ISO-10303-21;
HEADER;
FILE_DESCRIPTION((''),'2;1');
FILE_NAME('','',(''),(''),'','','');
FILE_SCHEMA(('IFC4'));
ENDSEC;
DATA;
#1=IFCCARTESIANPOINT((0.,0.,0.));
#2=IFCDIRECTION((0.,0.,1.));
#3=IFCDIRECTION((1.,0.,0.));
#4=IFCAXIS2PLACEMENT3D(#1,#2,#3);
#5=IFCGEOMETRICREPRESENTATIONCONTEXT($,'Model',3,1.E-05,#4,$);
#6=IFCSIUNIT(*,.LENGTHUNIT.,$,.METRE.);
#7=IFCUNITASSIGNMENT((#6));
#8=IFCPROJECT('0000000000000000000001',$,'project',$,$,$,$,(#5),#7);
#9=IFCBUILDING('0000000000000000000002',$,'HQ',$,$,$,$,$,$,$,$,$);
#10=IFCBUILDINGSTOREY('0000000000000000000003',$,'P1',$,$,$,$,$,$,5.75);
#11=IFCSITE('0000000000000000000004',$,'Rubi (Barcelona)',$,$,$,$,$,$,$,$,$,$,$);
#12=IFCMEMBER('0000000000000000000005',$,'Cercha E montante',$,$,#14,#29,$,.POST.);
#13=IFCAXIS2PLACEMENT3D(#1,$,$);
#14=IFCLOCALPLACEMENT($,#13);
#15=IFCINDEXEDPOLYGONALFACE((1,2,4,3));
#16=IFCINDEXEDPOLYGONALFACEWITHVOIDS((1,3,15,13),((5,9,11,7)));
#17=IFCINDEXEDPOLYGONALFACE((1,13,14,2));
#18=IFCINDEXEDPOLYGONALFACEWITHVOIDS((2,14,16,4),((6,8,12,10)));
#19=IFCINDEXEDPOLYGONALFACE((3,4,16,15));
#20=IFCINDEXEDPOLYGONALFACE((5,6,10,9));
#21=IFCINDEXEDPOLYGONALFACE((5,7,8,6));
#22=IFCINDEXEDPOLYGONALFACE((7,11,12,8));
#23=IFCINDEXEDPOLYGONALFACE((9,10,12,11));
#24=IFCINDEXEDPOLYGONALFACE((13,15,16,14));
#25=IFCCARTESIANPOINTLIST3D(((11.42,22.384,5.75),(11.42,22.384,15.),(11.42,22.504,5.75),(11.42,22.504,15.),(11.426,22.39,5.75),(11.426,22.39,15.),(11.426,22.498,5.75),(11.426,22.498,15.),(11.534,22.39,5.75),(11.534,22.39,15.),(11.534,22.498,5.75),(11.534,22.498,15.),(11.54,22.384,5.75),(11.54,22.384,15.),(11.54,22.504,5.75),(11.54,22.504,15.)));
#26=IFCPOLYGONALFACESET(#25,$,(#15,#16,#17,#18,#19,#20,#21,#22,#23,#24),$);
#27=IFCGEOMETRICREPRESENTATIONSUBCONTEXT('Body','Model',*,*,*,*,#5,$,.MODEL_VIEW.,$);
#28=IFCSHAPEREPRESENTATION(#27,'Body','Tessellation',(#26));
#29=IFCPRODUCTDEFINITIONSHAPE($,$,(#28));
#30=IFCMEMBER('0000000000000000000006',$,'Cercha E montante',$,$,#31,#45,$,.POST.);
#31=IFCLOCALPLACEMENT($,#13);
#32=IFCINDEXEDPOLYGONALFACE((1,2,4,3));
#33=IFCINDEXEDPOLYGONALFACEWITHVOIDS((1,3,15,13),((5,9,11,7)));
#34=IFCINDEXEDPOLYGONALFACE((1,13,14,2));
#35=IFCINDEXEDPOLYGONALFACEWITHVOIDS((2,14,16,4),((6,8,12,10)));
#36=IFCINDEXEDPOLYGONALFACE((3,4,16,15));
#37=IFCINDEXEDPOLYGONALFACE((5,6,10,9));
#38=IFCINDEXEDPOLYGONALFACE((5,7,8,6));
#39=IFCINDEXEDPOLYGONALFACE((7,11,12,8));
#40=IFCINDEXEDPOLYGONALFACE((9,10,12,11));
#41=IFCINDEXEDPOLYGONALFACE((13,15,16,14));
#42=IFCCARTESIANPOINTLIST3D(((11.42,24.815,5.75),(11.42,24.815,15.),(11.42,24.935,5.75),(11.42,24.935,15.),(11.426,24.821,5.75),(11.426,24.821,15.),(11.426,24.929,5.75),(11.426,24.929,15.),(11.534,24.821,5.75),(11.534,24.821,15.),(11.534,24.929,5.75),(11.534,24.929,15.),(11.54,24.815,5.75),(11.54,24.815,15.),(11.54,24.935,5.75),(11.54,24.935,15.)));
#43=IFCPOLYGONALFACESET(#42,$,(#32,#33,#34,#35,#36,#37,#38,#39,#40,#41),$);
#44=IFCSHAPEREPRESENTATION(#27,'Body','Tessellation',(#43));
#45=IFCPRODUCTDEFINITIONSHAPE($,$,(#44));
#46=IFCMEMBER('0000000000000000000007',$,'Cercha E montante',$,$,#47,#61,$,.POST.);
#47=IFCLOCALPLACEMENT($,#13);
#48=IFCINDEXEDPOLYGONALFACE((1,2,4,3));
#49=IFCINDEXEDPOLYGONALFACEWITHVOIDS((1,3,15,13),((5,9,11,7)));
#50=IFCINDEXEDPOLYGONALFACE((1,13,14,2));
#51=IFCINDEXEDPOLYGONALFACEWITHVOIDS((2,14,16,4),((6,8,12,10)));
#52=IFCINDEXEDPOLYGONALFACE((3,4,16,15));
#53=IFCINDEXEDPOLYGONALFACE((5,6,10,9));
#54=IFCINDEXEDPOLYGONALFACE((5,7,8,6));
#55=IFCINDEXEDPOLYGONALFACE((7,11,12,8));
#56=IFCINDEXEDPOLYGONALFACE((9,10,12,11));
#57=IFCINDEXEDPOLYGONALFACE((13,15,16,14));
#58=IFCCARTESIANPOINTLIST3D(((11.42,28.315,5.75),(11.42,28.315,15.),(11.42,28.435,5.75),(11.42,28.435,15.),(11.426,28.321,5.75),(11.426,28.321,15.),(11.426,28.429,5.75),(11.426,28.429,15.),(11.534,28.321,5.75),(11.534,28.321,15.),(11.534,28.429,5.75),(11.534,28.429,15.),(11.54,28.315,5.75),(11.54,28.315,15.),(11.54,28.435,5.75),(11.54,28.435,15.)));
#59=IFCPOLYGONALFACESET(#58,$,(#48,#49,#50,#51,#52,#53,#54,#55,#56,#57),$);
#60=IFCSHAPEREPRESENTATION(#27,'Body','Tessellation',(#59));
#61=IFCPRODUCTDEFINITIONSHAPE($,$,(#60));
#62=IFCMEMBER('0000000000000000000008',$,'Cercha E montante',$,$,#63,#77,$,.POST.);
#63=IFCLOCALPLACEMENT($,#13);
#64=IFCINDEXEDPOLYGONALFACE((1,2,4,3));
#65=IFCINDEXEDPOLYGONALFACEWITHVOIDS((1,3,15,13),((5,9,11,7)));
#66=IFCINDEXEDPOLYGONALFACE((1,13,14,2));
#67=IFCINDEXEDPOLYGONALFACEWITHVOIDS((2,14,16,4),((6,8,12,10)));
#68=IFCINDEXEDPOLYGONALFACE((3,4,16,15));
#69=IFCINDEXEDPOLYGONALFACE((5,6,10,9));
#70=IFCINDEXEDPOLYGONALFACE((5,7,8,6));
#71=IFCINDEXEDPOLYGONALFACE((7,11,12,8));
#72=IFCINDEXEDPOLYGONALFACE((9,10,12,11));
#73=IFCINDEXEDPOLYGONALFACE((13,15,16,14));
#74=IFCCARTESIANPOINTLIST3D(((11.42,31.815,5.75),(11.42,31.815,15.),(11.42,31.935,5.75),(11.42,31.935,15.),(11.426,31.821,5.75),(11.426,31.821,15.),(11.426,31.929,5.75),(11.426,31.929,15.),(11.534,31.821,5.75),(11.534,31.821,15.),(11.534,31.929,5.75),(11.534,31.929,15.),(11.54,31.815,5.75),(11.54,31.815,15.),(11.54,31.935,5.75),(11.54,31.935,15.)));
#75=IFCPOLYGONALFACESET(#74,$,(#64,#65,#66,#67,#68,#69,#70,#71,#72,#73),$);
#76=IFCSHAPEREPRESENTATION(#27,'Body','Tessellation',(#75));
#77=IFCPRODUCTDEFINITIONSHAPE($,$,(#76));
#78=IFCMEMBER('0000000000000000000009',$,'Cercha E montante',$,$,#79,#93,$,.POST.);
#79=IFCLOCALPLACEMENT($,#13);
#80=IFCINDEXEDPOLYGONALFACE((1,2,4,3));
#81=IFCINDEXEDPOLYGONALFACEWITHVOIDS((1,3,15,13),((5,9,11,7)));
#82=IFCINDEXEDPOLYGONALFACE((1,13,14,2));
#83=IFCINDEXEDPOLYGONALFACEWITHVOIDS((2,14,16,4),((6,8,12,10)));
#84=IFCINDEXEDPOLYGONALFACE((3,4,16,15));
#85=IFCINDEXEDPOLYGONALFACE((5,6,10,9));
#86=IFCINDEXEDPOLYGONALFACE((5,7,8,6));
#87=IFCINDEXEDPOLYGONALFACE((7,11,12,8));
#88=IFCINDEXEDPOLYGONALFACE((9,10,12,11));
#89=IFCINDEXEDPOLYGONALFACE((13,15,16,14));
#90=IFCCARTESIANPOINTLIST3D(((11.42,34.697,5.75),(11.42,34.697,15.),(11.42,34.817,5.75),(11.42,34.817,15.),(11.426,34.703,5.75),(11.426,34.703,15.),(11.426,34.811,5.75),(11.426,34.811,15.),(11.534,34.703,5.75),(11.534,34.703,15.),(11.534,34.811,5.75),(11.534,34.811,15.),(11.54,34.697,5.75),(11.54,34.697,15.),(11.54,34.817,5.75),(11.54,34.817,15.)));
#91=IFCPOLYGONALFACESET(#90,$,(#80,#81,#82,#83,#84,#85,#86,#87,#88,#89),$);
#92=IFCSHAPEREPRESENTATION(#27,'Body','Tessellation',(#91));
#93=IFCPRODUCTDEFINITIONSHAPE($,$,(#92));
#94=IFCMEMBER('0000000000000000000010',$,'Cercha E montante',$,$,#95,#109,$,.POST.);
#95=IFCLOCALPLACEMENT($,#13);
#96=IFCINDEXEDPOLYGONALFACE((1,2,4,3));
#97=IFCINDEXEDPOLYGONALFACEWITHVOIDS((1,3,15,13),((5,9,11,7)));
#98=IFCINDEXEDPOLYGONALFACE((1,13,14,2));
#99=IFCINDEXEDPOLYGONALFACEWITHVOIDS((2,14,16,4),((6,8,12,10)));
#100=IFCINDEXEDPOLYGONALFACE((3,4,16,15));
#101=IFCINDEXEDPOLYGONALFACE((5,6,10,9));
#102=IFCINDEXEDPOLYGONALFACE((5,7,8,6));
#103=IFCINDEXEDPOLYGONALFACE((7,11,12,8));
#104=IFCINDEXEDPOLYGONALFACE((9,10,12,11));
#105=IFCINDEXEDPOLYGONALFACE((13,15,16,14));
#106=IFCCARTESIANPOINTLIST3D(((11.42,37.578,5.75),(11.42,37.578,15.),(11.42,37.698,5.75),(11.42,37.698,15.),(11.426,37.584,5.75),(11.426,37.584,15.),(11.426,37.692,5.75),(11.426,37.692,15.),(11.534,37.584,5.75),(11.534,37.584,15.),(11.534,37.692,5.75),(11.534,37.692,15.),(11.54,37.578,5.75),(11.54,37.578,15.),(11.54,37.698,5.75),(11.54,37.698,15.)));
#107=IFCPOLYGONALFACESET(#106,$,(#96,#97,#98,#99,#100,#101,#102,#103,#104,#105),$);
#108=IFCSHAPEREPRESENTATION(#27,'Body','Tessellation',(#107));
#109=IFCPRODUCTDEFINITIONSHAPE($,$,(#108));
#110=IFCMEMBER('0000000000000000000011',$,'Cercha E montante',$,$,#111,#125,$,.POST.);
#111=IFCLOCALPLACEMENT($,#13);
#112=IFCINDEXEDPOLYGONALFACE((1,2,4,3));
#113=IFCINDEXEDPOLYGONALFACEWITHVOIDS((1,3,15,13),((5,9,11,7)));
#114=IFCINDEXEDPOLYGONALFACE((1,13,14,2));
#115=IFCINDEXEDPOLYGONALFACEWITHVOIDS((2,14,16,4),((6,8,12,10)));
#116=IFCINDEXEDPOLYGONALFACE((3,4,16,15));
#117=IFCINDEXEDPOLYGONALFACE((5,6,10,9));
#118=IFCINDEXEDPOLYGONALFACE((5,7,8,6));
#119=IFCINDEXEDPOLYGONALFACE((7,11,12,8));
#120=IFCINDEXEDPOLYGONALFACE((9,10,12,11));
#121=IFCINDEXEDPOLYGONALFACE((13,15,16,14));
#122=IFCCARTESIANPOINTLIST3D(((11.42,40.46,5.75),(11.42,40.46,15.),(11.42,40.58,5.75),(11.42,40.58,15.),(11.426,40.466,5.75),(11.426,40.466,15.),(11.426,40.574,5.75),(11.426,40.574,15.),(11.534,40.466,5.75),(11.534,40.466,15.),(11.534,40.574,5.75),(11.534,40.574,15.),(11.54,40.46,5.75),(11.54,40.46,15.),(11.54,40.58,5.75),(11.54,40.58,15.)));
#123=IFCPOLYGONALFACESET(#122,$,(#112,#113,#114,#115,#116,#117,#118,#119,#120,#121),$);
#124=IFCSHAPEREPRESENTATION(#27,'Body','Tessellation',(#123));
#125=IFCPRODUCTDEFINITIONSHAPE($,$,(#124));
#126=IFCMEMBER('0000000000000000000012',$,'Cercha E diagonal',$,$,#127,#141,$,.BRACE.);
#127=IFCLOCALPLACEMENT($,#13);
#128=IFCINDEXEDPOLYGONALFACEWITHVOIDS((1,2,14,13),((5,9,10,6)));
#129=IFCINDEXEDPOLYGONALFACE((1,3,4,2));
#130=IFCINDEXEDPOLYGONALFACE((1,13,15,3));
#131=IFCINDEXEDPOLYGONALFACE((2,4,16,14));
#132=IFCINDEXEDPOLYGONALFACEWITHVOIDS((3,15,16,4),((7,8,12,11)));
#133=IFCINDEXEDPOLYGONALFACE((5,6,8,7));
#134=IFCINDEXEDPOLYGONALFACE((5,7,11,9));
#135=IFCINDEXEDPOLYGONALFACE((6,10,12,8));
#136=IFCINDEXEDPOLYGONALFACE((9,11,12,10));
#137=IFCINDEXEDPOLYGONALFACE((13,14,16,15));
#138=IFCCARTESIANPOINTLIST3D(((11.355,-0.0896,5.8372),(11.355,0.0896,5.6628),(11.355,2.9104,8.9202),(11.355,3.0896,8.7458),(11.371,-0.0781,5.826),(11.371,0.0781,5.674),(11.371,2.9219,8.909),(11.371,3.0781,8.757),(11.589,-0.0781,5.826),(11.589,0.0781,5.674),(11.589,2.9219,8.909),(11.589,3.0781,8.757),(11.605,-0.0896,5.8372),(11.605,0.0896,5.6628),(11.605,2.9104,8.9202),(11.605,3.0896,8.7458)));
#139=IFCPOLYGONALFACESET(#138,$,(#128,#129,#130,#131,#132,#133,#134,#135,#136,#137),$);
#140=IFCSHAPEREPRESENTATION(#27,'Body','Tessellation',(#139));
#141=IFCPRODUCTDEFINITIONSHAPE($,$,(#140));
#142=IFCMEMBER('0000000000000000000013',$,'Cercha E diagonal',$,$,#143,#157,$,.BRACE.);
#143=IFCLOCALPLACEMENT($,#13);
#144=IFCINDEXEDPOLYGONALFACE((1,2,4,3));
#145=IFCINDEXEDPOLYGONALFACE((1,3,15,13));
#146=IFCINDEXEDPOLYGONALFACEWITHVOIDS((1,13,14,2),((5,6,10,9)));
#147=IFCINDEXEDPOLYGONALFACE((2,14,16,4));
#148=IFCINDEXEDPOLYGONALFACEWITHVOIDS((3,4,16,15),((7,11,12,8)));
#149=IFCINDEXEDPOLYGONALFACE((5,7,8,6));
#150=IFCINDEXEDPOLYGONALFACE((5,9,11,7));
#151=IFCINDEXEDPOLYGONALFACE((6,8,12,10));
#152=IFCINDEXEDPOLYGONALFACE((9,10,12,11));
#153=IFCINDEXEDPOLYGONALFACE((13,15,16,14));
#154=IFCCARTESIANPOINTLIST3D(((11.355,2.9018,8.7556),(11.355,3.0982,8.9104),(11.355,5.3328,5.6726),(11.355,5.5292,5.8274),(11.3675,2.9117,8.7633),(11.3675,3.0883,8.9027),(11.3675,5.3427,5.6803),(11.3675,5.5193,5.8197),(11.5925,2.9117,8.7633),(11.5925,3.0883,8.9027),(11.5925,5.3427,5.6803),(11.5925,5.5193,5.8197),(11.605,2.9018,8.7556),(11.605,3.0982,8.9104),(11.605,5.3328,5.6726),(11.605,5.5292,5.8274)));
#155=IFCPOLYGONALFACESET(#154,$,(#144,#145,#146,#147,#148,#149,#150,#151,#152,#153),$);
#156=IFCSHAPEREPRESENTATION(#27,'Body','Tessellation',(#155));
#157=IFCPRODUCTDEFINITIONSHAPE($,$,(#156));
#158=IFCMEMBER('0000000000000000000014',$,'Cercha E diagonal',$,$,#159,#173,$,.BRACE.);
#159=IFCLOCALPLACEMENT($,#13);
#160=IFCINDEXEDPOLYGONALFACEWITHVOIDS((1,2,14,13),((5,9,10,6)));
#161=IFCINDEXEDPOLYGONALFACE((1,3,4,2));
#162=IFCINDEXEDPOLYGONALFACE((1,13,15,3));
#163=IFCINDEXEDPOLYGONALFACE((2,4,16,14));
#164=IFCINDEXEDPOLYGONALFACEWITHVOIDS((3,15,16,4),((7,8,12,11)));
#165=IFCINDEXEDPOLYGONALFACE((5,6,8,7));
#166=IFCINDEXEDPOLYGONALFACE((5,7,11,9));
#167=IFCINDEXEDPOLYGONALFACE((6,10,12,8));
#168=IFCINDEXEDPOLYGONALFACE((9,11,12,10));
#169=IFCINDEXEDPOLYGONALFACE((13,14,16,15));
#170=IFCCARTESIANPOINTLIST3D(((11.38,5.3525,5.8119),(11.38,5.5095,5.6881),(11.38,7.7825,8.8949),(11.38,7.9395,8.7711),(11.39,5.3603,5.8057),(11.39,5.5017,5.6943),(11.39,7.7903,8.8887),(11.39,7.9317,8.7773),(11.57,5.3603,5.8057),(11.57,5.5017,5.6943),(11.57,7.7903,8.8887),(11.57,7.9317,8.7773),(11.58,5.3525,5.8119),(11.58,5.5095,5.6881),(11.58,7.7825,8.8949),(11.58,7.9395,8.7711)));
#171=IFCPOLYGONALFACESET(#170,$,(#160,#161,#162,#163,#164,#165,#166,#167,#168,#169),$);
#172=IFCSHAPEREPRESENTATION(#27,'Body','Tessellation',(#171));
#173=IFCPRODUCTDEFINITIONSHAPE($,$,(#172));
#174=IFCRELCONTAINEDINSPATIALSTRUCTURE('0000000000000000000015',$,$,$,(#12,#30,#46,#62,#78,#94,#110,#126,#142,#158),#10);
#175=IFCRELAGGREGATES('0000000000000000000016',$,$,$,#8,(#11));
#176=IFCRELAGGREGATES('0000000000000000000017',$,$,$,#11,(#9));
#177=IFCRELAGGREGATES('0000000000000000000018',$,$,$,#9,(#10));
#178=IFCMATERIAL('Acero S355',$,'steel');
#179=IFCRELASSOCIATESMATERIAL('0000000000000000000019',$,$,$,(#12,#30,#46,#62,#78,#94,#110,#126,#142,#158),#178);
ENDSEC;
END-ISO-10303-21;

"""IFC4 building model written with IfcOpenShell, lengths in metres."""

from ifc_helpers import new_model, si_unit, frame, origin_with_axes, place, context, subcontext, project, spatial, hollow_rectangle, extrude, material, element, save


model = new_model("IFC4")

# Units and contexts
model_context = context("Model", 3, precision=1e-05, world=origin_with_axes())
body_context = subcontext(model_context, "Body", "Model", "MODEL_VIEW")
ifc_project = project(units=[si_unit("LENGTHUNIT", "METRE")], contexts=[model_context])

# Site, building, storey
site = spatial("IfcSite", under=ifc_project, Name="Rubi (Barcelona)")
building = spatial("IfcBuilding", under=site, Name="HQ")
storey = spatial("IfcBuildingStorey", under=building, Name="P1", Elevation=5.75)

# Members
ifc_material = material(Name="Acero S355", Category="steel")
member_1_placement = place(None, origin_with_axes())
element("IfcMember", 1, at=member_1_placement, inside=storey, material=ifc_material, Name="Cercha E montante", PredefinedType="POST", context=body_context, shape_type="SweptSolid", body=[
    extrude(hollow_rectangle(XDim=0.12, YDim=0.12, WallThickness=0.006), frame((11.48, 22.444, 5.75), z_axis=(0.0, 0.0, 1.0), x_axis=(1.0, 0.0, 0.0)), (0.0, 0.0, 1.0), 9.25),
])
member_2_placement = place(None, origin_with_axes())
element("IfcMember", 2, at=member_2_placement, inside=storey, material=ifc_material, Name="Cercha E montante", PredefinedType="POST", context=body_context, shape_type="SweptSolid", body=[
    extrude(hollow_rectangle(XDim=0.12, YDim=0.12, WallThickness=0.006), frame((11.48, 24.875, 5.75), z_axis=(0.0, 0.0, 1.0), x_axis=(1.0, 0.0, 0.0)), (0.0, 0.0, 1.0), 9.25),
])
member_3_placement = place(None, origin_with_axes())
element("IfcMember", 3, at=member_3_placement, inside=storey, material=ifc_material, Name="Cercha E montante", PredefinedType="POST", context=body_context, shape_type="SweptSolid", body=[
    extrude(hollow_rectangle(XDim=0.12, YDim=0.12, WallThickness=0.006), frame((11.48, 28.375, 5.75), z_axis=(0.0, 0.0, 1.0), x_axis=(1.0, 0.0, 0.0)), (0.0, 0.0, 1.0), 9.25),
])
member_4_placement = place(None, origin_with_axes())
element("IfcMember", 4, at=member_4_placement, inside=storey, material=ifc_material, Name="Cercha E montante", PredefinedType="POST", context=body_context, shape_type="SweptSolid", body=[
    extrude(hollow_rectangle(XDim=0.12, YDim=0.12, WallThickness=0.006), frame((11.48, 31.875, 5.75), z_axis=(0.0, 0.0, 1.0), x_axis=(1.0, 0.0, 0.0)), (0.0, 0.0, 1.0), 9.25),
])
member_5_placement = place(None, origin_with_axes())
element("IfcMember", 5, at=member_5_placement, inside=storey, material=ifc_material, Name="Cercha E montante", PredefinedType="POST", context=body_context, shape_type="SweptSolid", body=[
    extrude(hollow_rectangle(XDim=0.12, YDim=0.12, WallThickness=0.006), frame((11.48, 34.757, 5.75), z_axis=(0.0, 0.0, 1.0), x_axis=(1.0, 0.0, 0.0)), (0.0, 0.0, 1.0), 9.25),
])
member_6_placement = place(None, origin_with_axes())
element("IfcMember", 6, at=member_6_placement, inside=storey, material=ifc_material, Name="Cercha E montante", PredefinedType="POST", context=body_context, shape_type="SweptSolid", body=[
    extrude(hollow_rectangle(XDim=0.12, YDim=0.12, WallThickness=0.006), frame((11.48, 37.638, 5.75), z_axis=(0.0, 0.0, 1.0), x_axis=(1.0, 0.0, 0.0)), (0.0, 0.0, 1.0), 9.25),
])
member_7_placement = place(None, origin_with_axes())
element("IfcMember", 7, at=member_7_placement, inside=storey, material=ifc_material, Name="Cercha E montante", PredefinedType="POST", context=body_context, shape_type="SweptSolid", body=[
    extrude(hollow_rectangle(XDim=0.12, YDim=0.12, WallThickness=0.006), frame((11.48, 40.52, 5.75), z_axis=(0.0, 0.0, 1.0), x_axis=(1.0, 0.0, 0.0)), (0.0, 0.0, 1.0), 9.25),
])
member_8_placement = place(None, origin_with_axes())
element("IfcMember", 8, at=member_8_placement, inside=storey, material=ifc_material, Name="Cercha E diagonal", PredefinedType="BRACE", context=body_context, shape_type="SweptSolid", body=[
    extrude(hollow_rectangle(XDim=0.25, YDim=0.25, WallThickness=0.016), frame((11.48, 0.0, 5.75), z_axis=(0.0, 0.697394, 0.716688), x_axis=(-1.0, 0.0, 0.0)), (0.0, 0.0, 1.0), 4.3017),
])
member_9_placement = place(None, origin_with_axes())
element("IfcMember", 9, at=member_9_placement, inside=storey, material=ifc_material, Name="Cercha E diagonal", PredefinedType="BRACE", context=body_context, shape_type="SweptSolid", body=[
    extrude(hollow_rectangle(XDim=0.25, YDim=0.25, WallThickness=0.0125), frame((11.48, 5.431, 5.75), z_axis=(0.0, -0.619182, 0.785248), x_axis=(1.0, 0.0, 0.0)), (0.0, 0.0, 1.0), 3.9261),
])
member_10_placement = place(None, origin_with_axes())
element("IfcMember", 10, at=member_10_placement, inside=storey, material=ifc_material, Name="Cercha E diagonal", PredefinedType="BRACE", context=body_context, shape_type="SweptSolid", body=[
    extrude(hollow_rectangle(XDim=0.2, YDim=0.2, WallThickness=0.01), frame((11.48, 5.431, 5.75), z_axis=(0.0, 0.619025, 0.785372), x_axis=(-1.0, 0.0, 0.0)), (0.0, 0.0, 1.0), 3.9255),
])

save(model, "model.ifc")
